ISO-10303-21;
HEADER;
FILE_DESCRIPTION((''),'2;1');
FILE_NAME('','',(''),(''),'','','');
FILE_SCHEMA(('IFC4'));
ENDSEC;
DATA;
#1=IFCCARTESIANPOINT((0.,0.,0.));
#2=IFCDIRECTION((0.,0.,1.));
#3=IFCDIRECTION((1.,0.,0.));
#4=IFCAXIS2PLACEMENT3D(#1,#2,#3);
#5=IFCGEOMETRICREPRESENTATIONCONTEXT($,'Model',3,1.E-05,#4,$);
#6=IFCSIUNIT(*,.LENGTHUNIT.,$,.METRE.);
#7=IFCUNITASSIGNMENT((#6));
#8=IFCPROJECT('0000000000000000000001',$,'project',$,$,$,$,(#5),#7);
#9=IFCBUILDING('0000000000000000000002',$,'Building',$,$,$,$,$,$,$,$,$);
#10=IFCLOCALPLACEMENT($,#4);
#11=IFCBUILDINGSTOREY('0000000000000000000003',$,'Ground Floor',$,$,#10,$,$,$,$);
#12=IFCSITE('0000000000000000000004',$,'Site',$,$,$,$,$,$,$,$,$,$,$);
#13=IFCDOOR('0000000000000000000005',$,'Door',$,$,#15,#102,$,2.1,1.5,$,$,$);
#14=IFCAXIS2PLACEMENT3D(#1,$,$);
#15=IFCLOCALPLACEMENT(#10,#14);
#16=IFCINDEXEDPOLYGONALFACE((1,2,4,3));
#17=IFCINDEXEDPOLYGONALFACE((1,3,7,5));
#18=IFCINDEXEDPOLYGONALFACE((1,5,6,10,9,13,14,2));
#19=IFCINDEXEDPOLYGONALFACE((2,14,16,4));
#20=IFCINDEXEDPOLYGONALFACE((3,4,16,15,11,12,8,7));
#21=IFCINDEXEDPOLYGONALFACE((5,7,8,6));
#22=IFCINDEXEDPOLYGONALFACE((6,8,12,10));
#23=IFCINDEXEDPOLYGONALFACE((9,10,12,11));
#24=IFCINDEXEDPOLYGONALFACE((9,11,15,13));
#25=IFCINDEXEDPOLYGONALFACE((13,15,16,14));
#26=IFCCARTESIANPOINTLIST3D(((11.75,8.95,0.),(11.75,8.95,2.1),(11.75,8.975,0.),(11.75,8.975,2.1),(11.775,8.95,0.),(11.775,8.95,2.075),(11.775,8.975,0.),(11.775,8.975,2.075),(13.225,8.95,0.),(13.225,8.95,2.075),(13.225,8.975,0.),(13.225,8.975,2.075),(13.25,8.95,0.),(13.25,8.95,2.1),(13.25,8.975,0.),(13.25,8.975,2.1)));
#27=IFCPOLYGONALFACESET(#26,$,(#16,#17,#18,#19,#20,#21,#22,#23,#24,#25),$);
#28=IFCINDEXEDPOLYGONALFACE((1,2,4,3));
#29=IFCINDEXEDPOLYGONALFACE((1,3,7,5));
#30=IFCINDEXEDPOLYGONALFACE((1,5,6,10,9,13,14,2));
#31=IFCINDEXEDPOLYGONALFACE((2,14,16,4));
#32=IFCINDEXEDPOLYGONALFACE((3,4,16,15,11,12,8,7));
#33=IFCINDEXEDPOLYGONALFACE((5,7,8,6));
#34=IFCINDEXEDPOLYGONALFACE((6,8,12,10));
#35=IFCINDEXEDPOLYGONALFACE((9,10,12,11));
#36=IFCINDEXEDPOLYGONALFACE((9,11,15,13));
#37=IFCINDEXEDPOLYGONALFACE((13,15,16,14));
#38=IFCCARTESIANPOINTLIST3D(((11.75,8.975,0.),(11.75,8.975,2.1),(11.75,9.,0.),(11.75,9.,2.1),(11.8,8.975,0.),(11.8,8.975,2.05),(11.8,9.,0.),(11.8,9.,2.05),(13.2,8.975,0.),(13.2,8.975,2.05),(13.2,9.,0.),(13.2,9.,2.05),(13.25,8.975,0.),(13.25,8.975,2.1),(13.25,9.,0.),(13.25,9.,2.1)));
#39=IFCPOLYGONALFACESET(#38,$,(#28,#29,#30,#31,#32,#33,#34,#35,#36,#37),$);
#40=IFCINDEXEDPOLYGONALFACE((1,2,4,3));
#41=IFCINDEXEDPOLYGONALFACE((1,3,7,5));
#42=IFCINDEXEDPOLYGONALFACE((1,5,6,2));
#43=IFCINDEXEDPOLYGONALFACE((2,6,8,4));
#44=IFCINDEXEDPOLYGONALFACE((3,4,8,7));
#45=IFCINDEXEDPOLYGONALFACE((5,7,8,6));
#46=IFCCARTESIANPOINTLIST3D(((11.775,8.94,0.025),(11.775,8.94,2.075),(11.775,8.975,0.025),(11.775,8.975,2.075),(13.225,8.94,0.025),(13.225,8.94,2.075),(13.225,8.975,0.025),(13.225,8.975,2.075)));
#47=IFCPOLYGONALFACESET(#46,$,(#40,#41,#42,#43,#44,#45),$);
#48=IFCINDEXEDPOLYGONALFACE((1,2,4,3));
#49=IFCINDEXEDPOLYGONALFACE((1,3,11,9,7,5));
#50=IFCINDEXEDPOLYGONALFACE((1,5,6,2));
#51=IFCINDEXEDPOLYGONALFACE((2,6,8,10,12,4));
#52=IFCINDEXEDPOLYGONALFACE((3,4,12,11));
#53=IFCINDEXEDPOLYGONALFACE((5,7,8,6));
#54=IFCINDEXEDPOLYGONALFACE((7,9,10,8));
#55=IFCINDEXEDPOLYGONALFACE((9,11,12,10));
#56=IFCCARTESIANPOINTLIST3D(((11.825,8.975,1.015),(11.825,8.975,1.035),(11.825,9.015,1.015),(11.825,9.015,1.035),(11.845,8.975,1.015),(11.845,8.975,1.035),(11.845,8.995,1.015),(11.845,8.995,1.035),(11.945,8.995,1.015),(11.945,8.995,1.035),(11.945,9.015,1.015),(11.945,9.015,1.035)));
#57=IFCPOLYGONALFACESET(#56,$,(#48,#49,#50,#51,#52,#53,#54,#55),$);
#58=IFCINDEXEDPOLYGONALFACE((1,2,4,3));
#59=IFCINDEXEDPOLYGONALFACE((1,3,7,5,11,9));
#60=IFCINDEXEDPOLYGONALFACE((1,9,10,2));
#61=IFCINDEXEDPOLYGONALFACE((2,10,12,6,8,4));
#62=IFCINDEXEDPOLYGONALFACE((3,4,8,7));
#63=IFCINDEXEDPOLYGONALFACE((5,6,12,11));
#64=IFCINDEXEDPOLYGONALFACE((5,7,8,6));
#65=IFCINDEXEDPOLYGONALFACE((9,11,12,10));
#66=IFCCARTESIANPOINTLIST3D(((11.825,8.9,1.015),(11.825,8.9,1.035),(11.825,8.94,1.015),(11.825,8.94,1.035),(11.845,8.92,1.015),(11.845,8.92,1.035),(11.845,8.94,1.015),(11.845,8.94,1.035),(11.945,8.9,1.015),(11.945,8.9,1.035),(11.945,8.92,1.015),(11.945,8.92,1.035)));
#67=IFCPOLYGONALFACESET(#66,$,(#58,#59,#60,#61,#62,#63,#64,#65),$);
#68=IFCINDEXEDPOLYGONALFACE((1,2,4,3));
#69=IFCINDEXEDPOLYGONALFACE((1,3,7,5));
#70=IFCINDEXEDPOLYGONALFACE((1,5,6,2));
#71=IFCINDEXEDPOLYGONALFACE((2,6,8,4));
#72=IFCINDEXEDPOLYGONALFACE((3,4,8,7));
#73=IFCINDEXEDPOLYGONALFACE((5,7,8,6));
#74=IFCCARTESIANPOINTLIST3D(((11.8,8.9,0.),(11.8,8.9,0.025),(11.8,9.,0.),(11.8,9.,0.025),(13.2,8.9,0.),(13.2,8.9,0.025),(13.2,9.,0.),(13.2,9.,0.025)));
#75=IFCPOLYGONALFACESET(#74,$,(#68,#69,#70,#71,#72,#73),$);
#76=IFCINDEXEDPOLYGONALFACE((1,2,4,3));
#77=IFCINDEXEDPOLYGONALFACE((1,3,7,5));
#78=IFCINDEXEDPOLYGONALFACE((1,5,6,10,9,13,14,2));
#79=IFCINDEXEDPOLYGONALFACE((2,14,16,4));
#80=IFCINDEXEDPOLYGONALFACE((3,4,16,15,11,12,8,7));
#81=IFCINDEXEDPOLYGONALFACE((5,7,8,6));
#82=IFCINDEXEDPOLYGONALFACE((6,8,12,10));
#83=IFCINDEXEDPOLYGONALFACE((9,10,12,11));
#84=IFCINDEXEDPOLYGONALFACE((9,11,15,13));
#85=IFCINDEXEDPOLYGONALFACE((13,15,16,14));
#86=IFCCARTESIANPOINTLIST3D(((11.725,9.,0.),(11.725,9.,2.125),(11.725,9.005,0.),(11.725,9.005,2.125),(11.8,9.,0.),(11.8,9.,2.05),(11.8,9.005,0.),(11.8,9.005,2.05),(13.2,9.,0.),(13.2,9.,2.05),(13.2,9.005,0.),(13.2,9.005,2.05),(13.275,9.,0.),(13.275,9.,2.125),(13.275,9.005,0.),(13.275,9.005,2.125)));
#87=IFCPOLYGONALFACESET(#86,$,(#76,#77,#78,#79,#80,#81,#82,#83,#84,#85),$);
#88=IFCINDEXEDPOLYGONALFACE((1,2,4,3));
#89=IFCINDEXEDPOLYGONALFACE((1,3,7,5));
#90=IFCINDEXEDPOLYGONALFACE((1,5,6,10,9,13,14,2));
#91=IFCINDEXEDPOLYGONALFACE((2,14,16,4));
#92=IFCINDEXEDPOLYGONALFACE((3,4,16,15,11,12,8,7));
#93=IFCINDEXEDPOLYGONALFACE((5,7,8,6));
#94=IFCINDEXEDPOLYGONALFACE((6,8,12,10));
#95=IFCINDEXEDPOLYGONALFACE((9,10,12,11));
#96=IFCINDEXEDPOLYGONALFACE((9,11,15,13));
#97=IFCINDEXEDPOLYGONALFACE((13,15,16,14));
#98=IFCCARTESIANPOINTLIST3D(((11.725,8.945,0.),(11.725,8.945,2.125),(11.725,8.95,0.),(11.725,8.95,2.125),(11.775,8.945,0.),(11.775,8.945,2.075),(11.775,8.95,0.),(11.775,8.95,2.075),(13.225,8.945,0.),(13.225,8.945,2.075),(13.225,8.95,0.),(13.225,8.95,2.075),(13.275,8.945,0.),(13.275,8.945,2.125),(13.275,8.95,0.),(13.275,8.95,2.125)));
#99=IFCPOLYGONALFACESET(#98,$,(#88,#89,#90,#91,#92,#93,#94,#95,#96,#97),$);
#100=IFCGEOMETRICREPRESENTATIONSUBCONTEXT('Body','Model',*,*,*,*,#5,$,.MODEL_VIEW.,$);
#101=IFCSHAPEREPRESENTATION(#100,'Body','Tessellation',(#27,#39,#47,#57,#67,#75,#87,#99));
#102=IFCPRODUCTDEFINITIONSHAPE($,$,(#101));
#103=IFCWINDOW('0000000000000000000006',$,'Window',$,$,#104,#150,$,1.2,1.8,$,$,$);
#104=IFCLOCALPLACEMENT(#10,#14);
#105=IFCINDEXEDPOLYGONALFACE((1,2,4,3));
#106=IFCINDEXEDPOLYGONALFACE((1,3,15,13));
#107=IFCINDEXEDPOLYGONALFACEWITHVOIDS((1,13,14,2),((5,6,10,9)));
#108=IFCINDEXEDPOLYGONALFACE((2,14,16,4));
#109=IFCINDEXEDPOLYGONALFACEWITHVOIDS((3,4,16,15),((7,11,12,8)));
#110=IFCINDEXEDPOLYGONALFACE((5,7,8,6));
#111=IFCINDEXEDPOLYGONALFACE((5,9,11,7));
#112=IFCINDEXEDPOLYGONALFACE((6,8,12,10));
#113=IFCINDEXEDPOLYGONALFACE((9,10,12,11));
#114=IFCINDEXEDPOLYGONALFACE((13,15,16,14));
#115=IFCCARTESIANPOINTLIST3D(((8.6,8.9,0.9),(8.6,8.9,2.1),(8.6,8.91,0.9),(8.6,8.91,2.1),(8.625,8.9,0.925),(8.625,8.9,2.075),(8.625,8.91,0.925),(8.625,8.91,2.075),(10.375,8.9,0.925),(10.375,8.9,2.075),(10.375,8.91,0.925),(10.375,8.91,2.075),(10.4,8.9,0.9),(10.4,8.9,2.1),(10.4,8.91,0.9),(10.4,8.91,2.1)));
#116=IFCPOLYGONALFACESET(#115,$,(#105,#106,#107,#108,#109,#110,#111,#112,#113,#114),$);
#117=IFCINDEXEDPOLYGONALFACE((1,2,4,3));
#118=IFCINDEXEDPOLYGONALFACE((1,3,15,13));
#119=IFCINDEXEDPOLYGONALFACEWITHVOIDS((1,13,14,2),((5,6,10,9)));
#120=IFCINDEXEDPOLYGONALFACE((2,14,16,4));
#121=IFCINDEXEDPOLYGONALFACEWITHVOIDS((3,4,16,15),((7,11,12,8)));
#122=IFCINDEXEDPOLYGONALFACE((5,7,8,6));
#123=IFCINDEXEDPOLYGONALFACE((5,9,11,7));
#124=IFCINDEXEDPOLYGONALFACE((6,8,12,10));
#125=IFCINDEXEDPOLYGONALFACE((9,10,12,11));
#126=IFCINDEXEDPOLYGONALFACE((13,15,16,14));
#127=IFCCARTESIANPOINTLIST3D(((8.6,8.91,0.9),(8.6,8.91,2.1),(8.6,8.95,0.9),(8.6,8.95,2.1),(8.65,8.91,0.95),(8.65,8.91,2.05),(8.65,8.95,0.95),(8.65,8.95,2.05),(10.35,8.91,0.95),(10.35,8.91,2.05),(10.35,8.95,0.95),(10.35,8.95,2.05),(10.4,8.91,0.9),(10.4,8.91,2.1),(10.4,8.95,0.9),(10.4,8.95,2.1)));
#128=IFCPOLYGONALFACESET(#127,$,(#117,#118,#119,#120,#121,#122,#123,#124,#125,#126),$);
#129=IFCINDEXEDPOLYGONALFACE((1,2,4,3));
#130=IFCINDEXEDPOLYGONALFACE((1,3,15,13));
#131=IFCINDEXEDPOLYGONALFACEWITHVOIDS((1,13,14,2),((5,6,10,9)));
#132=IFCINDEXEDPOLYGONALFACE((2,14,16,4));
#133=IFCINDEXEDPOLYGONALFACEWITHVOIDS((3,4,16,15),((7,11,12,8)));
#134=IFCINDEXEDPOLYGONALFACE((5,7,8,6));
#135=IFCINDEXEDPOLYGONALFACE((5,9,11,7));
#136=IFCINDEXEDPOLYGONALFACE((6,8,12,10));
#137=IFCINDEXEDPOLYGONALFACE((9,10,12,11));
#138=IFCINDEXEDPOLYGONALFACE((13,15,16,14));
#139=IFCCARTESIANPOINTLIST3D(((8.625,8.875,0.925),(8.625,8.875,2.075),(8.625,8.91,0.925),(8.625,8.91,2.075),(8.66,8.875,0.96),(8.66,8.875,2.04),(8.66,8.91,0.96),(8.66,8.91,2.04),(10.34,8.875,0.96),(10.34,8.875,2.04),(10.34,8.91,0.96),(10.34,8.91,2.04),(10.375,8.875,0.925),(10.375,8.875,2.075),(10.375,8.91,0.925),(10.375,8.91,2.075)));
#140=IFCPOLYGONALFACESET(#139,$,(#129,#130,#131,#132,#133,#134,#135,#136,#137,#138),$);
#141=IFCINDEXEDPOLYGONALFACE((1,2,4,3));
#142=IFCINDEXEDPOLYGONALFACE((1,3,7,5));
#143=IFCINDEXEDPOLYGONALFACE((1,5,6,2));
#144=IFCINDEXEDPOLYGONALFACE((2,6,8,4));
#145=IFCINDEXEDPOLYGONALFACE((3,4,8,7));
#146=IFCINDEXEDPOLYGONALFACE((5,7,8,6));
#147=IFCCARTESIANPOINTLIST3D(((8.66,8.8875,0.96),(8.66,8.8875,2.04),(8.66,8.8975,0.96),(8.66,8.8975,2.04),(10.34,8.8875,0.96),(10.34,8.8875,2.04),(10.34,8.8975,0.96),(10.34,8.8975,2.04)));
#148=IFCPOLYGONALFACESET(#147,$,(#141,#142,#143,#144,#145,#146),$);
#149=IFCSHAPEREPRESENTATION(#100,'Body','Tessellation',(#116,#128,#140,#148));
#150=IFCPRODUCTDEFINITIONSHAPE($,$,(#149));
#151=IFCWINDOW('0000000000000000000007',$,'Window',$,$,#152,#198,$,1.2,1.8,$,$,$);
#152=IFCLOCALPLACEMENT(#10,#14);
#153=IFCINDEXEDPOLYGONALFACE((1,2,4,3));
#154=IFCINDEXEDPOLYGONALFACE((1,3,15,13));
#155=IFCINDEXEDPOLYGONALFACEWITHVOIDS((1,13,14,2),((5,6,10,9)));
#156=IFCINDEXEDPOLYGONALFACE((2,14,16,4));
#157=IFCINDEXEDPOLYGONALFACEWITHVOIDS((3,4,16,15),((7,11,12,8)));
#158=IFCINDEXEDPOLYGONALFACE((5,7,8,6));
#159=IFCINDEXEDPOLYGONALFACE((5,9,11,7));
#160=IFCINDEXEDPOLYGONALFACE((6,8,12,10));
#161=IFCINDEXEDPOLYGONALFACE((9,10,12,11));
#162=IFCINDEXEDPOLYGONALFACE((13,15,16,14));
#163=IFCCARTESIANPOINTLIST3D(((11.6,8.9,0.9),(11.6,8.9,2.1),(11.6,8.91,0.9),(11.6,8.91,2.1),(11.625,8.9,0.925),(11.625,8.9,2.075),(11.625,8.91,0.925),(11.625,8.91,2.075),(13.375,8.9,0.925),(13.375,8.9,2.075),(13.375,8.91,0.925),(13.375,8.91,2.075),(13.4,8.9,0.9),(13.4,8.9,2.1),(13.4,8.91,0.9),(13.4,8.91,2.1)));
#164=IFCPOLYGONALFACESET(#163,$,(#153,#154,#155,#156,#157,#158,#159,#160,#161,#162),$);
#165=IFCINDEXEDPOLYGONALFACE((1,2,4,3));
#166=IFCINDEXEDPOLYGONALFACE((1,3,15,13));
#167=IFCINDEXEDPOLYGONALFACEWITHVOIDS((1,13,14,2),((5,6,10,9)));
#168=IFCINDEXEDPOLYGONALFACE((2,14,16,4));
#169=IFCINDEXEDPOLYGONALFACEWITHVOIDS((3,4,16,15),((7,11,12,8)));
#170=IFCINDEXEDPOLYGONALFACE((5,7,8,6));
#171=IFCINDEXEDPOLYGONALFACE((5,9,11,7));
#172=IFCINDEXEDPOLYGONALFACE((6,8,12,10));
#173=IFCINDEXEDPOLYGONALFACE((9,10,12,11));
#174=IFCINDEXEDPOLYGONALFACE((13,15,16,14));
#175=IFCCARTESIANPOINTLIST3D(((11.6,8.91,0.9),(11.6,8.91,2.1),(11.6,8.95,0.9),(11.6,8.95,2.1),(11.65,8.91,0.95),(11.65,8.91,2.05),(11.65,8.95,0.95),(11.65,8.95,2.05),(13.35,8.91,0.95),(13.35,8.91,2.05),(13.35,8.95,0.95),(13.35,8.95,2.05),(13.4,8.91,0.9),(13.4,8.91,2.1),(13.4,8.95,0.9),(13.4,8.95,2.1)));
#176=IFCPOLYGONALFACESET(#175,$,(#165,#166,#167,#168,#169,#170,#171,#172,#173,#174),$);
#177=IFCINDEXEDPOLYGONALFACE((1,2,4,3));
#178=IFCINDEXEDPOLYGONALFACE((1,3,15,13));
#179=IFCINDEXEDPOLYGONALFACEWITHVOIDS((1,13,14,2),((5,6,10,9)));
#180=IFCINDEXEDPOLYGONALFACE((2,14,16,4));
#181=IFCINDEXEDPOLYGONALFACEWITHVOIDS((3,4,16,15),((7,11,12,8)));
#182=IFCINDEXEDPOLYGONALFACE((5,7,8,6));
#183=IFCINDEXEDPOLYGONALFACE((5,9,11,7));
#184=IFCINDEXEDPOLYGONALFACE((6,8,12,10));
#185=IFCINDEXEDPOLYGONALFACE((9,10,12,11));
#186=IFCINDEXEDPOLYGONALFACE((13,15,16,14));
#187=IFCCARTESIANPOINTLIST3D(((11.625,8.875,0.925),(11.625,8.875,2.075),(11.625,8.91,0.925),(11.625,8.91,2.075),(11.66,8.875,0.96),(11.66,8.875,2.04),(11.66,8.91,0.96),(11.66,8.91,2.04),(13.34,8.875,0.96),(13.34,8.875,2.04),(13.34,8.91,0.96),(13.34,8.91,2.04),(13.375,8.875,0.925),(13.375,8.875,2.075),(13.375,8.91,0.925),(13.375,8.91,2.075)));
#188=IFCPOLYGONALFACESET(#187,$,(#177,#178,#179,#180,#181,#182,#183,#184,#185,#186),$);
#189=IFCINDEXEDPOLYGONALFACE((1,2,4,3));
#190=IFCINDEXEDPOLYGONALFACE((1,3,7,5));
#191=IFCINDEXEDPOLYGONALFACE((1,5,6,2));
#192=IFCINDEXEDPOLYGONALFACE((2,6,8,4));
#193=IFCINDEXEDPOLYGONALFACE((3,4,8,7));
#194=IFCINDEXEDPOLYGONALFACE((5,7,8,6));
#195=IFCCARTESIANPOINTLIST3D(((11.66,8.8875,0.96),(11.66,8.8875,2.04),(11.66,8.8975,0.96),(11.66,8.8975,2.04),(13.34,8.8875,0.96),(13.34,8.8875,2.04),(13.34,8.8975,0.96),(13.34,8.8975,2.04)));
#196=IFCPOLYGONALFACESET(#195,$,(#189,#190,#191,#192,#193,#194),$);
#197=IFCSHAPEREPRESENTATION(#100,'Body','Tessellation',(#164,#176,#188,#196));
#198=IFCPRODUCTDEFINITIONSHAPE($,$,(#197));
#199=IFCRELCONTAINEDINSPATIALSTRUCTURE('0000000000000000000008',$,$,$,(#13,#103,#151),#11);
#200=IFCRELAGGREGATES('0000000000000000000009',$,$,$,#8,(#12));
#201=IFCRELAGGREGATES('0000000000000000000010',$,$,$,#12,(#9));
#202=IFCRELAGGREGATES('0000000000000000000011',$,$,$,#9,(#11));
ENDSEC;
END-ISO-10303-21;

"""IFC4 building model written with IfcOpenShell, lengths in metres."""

from ifc_helpers import new_model, si_unit, frame, origin_with_axes, place, context, subcontext, project, spatial, line, indexed_curve, outline, extrude, element, save


model = new_model("IFC4")

# Units and contexts
model_context = context("Model", 3, precision=1e-05, world=origin_with_axes())
body_context = subcontext(model_context, "Body", "Model", "MODEL_VIEW")
ifc_project = project(units=[si_unit("LENGTHUNIT", "METRE")], contexts=[model_context])

# Site, building, storey
site = spatial("IfcSite", under=ifc_project, Name="Site")
building = spatial("IfcBuilding", under=site, Name="Building")
storey_placement = place(None, origin_with_axes())
storey = spatial("IfcBuildingStorey", under=building, at=storey_placement, Name="Ground Floor")

# Door
door_1_placement = place(storey_placement, frame((13.25, 9.0, 0.0), z_axis=(0.0, 0.0, 1.0), x_axis=(-1.0, 0.0, 0.0)))
element("IfcDoor", 1, at=door_1_placement, inside=storey, Name="Door", OverallHeight=2.1, OverallWidth=1.5, context=body_context, shape_type="SweptSolid", body=[
    extrude(outline(indexed_curve([(0.0, 0.0), (0.0, 2.1), (1.5, 2.1), (1.5, 0.0), (1.475, 0.0), (1.475, 2.075), (0.025, 2.075), (0.025, 0.0)], segments=[line(1, 2, 3, 4, 5, 6, 7, 8, 1)])), frame((0.0, 0.025, 0.0), z_axis=(0.0, -1.0, 0.0), x_axis=(1.0, 0.0, 0.0)), (0.0, 0.0, -1.0), 0.025),
    extrude(outline(indexed_curve([(0.0, 0.0), (0.0, 2.1), (1.5, 2.1), (1.5, 0.0), (1.45, 0.0), (1.45, 2.05), (0.05, 2.05), (0.05, 0.0)], segments=[line(1, 2, 3, 4, 5, 6, 7, 8, 1)])), frame((0.0, 0.0, 0.0), z_axis=(0.0, -1.0, 0.0), x_axis=(1.0, 0.0, 0.0)), (0.0, 0.0, -1.0), 0.025),
    extrude(outline(indexed_curve([(0.0, 0.0), (1.45, 0.0), (1.45, 0.035), (0.0, 0.035)], segments=[line(1, 2, 3, 4, 1)])), frame((0.025, 0.025, 0.025), z_axis=(0.0, 0.0, 1.0), x_axis=(1.0, 0.0, 0.0)), (0.0, 0.0, 1.0), 2.05),
    extrude(outline(indexed_curve([(0.0, 0.0), (0.0, -0.04), (-0.12, -0.04), (-0.12, -0.02), (-0.02, -0.02), (-0.02, 0.0)], segments=[line(1, 2, 3, 4, 5, 6, 1)])), frame((1.425, 0.025, 1.015), z_axis=(0.0, 0.0, 1.0), x_axis=(1.0, 0.0, 0.0)), (0.0, 0.0, 1.0), 0.02),
    extrude(outline(indexed_curve([(0.0, 0.0), (0.0, 0.04), (-0.12, 0.04), (-0.12, 0.02), (-0.02, 0.02), (-0.02, 0.0)], segments=[line(1, 2, 3, 4, 5, 6, 1)])), frame((1.425, 0.06, 1.015), z_axis=(0.0, 0.0, 1.0), x_axis=(1.0, 0.0, 0.0)), (0.0, 0.0, 1.0), 0.02),
    extrude(outline(indexed_curve([(0.0, 0.0), (1.4, 0.0), (1.4, 0.1), (0.0, 0.1)], segments=[line(1, 2, 3, 4, 1)])), frame((0.05, 0.0, 0.0), z_axis=(0.0, 0.0, 1.0), x_axis=(1.0, 0.0, 0.0)), (0.0, 0.0, 1.0), 0.025),
    extrude(outline(indexed_curve([(0.0, 0.0), (0.0, 2.125), (1.55, 2.125), (1.55, 0.0), (1.475, 0.0), (1.475, 2.05), (0.075, 2.05), (0.075, 0.0)], segments=[line(1, 2, 3, 4, 5, 6, 7, 8, 1)])), frame((-0.025, -0.005, 0.0), z_axis=(0.0, -1.0, 0.0), x_axis=(1.0, 0.0, 0.0)), (0.0, 0.0, -1.0), 0.005),
    extrude(outline(indexed_curve([(0.0, 0.0), (0.0, 2.125), (1.55, 2.125), (1.55, 0.0), (1.5, 0.0), (1.5, 2.075), (0.05, 2.075), (0.05, 0.0)], segments=[line(1, 2, 3, 4, 5, 6, 7, 8, 1)])), frame((-0.025, 0.05, 0.0), z_axis=(0.0, -1.0, 0.0), x_axis=(1.0, 0.0, 0.0)), (0.0, 0.0, -1.0), 0.005),
])

# Windows
for number, where, z_axis, x_axis, name in (
    (2, (10.4, 9.0, 0.9), (0.0, 0.0, 1.0), (-1.0, 0.0, 0.0), "Window"),
    (3, (13.4, 9.0, 0.9), (0.0, 0.0, 1.0), (-1.0, 0.0, 0.0), "Window"),
):
    element("IfcWindow", number, at=place(storey_placement, frame(where, z_axis=z_axis, x_axis=x_axis)), inside=storey, Name=name, OverallHeight=1.2, OverallWidth=1.8, context=body_context, shape_type="SweptSolid", body=[
        extrude(outline(indexed_curve([(0.0, 0.0), (1.8, 0.0), (1.8, 1.2), (0.0, 1.2)], segments=[line(1, 2, 3, 4, 1)]), holes=[indexed_curve([(0.025, 0.025), (1.775, 0.025), (1.775, 1.175), (0.025, 1.175)], segments=[line(1, 2, 3, 4, 1)])]), frame((0.0, 0.09, 0.0), z_axis=(0.0, -1.0, 0.0), x_axis=(1.0, 0.0, 0.0)), (0.0, 0.0, -1.0), 0.01),
        extrude(outline(indexed_curve([(0.0, 0.0), (1.8, 0.0), (1.8, 1.2), (0.0, 1.2)], segments=[line(1, 2, 3, 4, 1)]), holes=[indexed_curve([(0.05, 0.05), (1.75, 0.05), (1.75, 1.15), (0.05, 1.15)], segments=[line(1, 2, 3, 4, 1)])]), frame((0.0, 0.05, 0.0), z_axis=(0.0, -1.0, 0.0), x_axis=(1.0, 0.0, 0.0)), (0.0, 0.0, -1.0), 0.04),
        extrude(outline(indexed_curve([(0.0, 0.0), (1.75, 0.0), (1.75, 1.15), (0.0, 1.15)], segments=[line(1, 2, 3, 4, 1)]), holes=[indexed_curve([(0.035, 0.035), (1.715, 0.035), (1.715, 1.115), (0.035, 1.115)], segments=[line(1, 2, 3, 4, 1)])]), frame((0.025, 0.09, 0.025), z_axis=(0.0, -1.0, 0.0), x_axis=(1.0, 0.0, 0.0)), (0.0, 0.0, -1.0), 0.035),
        extrude(outline(indexed_curve([(0.035, 0.035), (1.715, 0.035), (1.715, 1.115), (0.035, 1.115)], segments=[line(1, 2, 3, 4, 1)])), frame((0.025, 0.1025, 0.025), z_axis=(0.0, -1.0, 0.0), x_axis=(1.0, 0.0, 0.0)), (0.0, 0.0, -1.0), 0.01),
    ])

save(model, "model.ifc")
